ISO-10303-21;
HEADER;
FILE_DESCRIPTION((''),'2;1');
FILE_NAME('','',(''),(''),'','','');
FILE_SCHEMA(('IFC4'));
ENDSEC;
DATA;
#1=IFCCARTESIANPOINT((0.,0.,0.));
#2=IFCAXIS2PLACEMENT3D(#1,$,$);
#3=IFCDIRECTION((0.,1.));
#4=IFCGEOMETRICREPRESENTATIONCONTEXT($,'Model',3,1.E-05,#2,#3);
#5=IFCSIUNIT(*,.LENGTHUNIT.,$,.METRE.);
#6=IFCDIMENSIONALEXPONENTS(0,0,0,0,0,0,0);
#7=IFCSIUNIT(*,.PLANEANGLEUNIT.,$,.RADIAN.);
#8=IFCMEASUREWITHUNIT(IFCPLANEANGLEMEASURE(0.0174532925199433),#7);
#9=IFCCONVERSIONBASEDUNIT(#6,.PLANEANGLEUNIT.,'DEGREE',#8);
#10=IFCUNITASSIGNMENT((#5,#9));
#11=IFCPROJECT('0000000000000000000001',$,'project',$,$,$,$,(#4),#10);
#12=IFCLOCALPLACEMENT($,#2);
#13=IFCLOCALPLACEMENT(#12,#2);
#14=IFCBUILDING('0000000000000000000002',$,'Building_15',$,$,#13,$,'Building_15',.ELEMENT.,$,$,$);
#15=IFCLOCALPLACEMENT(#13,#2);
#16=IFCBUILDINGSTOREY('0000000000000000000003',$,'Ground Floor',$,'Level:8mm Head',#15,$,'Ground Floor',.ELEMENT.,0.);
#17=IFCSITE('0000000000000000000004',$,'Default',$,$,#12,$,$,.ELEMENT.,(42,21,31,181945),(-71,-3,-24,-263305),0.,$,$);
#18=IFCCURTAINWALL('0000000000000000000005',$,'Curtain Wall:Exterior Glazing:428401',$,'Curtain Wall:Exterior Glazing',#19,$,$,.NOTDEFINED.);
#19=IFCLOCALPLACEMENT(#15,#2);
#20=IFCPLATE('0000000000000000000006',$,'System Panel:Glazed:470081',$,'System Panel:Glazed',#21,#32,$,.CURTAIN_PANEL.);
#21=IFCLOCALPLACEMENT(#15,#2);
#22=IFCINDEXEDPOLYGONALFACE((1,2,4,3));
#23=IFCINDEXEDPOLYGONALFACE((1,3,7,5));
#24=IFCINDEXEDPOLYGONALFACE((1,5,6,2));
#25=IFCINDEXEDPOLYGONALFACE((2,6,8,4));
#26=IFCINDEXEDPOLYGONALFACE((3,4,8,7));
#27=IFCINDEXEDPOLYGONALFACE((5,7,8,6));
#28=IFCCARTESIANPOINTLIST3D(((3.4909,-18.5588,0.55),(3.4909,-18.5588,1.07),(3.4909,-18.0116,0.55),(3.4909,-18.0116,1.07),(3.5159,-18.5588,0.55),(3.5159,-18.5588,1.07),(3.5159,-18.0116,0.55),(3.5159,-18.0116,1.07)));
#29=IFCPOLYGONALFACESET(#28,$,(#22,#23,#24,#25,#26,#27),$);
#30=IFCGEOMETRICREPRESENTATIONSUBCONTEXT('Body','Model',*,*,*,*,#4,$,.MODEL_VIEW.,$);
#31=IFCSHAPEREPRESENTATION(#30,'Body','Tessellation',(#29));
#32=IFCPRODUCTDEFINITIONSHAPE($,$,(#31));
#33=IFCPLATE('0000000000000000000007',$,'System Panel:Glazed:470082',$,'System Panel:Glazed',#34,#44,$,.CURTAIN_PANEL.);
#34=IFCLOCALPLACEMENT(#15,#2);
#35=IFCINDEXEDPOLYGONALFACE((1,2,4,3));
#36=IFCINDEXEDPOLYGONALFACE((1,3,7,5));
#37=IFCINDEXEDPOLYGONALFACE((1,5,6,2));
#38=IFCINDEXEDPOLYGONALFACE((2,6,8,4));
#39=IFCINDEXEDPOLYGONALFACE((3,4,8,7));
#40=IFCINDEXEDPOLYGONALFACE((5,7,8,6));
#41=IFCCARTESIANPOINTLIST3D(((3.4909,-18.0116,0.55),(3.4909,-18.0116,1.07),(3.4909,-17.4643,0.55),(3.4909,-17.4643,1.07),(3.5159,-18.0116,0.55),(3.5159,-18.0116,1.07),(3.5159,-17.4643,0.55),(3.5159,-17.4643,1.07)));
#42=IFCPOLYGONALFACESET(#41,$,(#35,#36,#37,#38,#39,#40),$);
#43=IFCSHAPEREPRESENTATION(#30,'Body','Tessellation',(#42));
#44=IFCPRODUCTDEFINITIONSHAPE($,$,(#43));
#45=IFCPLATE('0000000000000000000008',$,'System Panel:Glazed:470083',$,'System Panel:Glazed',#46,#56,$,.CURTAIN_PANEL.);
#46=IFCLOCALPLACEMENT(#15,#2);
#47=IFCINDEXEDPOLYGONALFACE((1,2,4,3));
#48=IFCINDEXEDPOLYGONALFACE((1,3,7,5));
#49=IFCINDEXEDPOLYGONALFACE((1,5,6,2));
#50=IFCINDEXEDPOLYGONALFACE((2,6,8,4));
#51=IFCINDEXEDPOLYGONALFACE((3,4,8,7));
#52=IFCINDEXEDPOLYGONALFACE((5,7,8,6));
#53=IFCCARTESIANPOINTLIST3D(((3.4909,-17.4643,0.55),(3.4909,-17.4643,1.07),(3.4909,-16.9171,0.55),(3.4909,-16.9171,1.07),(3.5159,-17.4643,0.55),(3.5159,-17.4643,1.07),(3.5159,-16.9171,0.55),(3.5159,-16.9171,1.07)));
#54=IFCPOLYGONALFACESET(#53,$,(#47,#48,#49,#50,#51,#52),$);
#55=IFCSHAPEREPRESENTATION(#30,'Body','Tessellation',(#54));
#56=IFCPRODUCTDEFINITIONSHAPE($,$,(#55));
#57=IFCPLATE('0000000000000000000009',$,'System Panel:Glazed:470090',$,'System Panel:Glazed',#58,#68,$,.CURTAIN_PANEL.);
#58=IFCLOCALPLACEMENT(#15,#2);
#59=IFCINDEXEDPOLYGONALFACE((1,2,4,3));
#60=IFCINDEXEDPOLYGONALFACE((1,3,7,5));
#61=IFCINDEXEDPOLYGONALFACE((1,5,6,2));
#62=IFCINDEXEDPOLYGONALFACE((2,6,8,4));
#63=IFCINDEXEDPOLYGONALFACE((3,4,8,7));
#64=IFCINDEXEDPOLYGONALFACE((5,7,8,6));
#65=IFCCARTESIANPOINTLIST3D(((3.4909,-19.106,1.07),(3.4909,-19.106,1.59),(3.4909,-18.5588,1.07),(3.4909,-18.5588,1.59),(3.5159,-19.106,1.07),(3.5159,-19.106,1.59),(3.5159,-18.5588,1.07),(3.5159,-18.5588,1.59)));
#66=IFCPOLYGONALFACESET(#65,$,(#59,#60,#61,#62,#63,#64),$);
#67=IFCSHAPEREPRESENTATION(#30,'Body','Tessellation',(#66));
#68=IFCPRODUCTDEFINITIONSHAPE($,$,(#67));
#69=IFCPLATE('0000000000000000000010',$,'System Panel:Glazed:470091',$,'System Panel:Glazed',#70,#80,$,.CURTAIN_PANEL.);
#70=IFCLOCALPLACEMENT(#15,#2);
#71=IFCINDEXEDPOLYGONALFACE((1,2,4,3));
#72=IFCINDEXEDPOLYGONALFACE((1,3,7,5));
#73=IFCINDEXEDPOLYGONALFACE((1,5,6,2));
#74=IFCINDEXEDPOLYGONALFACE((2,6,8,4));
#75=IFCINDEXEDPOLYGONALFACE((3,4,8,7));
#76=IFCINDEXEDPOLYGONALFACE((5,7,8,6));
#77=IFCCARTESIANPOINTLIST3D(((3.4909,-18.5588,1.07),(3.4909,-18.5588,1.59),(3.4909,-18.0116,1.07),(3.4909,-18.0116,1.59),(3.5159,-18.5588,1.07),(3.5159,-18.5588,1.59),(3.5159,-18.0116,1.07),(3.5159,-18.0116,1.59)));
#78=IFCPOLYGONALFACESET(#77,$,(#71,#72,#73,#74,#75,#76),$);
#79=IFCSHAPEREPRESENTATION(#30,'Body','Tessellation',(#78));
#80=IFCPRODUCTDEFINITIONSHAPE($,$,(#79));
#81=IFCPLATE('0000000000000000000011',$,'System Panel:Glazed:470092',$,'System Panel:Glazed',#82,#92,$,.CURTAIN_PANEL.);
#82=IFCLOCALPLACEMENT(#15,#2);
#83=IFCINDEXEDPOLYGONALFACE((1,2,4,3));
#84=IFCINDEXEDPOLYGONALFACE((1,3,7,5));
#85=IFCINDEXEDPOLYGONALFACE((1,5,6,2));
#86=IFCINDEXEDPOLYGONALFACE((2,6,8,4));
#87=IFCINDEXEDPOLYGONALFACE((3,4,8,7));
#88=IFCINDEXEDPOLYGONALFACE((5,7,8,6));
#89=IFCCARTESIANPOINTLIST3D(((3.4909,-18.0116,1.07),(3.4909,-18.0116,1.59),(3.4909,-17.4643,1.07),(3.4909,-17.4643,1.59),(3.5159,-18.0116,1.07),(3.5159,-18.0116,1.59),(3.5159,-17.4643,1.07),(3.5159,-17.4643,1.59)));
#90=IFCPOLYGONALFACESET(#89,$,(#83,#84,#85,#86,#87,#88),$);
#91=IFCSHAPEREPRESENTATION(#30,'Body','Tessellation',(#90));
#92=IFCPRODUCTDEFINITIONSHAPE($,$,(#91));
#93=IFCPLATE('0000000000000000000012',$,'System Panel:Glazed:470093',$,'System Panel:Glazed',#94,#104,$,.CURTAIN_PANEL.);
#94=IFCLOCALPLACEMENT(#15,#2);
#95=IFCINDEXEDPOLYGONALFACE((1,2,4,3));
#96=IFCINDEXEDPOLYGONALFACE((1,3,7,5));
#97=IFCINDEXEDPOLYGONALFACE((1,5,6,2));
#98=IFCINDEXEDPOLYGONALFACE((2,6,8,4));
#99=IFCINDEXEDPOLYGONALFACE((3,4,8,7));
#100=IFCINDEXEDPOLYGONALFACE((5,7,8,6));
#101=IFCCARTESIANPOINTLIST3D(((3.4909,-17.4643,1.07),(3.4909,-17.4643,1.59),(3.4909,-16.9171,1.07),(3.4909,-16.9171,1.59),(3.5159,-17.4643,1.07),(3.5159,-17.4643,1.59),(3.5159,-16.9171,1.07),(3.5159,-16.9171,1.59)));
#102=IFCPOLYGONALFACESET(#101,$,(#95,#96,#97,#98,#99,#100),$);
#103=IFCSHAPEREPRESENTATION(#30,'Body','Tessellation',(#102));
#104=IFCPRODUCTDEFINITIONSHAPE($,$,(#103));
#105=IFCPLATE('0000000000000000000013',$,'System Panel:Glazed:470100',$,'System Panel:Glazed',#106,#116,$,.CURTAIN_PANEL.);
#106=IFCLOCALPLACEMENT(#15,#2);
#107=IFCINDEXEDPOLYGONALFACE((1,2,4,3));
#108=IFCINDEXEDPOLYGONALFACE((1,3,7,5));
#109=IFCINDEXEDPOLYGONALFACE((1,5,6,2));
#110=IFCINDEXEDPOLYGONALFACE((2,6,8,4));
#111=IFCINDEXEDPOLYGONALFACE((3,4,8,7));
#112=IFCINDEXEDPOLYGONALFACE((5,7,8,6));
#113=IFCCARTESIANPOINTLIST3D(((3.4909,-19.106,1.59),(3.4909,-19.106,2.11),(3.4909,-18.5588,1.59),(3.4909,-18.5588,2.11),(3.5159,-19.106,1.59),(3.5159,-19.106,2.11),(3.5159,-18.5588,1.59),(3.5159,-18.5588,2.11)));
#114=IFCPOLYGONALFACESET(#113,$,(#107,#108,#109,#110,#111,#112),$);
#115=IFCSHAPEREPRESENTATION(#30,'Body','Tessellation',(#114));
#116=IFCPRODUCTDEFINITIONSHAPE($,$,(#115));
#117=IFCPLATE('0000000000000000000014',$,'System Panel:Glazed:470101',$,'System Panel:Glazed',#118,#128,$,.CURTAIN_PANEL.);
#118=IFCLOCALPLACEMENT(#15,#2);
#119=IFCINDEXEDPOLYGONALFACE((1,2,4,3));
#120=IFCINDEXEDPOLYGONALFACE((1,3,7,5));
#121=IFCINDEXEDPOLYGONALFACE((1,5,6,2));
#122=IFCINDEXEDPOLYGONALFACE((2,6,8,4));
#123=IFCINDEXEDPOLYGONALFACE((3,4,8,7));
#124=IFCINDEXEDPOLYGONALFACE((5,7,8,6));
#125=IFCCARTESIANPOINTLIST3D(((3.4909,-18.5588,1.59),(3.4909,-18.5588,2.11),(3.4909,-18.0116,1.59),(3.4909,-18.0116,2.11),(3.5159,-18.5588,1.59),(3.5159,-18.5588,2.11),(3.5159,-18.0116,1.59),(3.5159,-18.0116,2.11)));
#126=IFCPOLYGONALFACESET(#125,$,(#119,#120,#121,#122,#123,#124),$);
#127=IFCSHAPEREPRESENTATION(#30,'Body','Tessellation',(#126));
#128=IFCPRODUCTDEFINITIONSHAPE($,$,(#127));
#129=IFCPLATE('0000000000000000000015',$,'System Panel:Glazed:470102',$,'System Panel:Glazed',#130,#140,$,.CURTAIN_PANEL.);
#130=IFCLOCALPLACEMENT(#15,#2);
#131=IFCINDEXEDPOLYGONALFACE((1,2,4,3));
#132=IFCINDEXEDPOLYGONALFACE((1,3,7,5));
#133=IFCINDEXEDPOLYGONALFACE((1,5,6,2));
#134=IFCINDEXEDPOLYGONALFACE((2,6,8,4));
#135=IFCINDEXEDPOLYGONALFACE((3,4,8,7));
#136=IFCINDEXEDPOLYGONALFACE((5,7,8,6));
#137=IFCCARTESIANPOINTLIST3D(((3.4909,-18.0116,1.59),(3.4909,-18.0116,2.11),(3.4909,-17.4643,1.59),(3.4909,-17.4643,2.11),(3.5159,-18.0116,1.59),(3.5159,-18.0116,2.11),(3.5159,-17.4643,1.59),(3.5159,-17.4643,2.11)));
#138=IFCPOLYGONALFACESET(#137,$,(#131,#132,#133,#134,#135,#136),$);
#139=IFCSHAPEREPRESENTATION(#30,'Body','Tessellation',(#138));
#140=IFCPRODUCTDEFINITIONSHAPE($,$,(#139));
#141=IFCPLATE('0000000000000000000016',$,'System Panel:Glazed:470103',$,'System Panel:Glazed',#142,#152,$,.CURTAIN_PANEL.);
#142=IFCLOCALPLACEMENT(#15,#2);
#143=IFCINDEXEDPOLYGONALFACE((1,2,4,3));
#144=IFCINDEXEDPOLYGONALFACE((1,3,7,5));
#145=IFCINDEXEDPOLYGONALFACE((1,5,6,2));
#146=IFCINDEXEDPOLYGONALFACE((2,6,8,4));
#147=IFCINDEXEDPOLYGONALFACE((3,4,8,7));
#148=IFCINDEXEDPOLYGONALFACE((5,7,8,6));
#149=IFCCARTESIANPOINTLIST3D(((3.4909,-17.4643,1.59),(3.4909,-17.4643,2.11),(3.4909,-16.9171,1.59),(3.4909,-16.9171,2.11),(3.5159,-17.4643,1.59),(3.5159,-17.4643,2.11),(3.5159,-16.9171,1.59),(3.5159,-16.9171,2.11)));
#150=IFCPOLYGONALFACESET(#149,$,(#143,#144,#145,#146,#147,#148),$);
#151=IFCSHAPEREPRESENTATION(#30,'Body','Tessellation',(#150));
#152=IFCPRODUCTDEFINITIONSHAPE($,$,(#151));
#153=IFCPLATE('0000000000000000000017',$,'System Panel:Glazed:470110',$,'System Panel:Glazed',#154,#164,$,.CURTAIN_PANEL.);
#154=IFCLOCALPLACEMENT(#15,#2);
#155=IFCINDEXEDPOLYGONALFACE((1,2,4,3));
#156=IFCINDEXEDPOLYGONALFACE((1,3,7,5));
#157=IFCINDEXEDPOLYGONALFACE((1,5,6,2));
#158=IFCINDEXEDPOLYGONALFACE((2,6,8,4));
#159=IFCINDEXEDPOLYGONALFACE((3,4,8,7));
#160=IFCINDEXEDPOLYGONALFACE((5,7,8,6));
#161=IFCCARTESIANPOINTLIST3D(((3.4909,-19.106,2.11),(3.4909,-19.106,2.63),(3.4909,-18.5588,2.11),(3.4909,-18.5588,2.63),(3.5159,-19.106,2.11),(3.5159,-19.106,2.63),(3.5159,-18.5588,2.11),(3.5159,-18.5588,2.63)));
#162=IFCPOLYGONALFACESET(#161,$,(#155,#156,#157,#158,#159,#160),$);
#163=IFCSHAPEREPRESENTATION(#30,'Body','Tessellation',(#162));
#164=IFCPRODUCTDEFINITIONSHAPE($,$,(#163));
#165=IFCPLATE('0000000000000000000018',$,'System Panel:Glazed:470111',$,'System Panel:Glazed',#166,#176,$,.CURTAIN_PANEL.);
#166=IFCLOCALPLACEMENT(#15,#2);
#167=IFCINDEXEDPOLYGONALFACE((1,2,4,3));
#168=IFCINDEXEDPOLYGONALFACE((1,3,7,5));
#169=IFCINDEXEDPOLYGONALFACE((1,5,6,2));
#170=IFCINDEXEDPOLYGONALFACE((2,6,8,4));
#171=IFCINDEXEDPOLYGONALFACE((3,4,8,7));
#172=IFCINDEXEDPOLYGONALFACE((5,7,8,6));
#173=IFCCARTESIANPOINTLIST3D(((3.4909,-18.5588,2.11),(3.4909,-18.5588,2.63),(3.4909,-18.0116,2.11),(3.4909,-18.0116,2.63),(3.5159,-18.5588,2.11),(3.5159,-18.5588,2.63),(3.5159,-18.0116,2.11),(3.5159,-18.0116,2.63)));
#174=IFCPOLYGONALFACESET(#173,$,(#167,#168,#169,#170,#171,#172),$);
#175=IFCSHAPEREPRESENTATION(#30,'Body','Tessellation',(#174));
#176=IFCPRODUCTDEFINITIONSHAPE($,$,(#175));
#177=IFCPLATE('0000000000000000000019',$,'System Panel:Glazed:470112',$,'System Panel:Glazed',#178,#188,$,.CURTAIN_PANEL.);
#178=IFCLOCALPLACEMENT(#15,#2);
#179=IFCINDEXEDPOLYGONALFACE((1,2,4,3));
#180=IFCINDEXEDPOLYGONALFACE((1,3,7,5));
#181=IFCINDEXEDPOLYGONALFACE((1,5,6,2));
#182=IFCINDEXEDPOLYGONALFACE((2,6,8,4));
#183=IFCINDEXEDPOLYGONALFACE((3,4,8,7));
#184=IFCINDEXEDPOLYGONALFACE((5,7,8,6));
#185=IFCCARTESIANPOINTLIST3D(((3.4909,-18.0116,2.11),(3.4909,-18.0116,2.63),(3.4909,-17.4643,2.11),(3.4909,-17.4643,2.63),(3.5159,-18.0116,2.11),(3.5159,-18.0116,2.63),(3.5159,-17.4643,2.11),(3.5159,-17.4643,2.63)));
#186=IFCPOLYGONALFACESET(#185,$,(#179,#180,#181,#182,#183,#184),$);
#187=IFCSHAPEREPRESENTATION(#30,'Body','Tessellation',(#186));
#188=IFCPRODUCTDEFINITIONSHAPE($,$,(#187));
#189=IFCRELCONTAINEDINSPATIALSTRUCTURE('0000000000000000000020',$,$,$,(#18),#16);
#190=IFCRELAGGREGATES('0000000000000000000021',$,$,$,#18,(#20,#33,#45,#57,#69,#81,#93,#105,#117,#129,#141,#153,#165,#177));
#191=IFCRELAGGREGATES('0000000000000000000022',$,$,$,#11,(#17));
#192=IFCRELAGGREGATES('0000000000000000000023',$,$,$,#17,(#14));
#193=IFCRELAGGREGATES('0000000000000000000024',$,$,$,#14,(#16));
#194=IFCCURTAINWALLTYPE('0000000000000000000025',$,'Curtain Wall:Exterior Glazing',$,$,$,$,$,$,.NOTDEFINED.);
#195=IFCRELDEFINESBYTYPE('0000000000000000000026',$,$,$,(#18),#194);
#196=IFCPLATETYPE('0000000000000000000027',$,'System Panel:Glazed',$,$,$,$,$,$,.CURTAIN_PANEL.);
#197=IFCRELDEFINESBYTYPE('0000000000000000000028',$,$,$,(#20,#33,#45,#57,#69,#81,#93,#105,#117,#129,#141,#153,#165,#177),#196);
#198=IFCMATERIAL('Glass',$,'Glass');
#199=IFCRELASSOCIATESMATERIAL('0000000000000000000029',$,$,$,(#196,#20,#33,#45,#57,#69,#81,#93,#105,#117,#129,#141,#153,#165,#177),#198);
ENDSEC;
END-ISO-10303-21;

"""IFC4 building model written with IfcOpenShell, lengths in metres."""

from ifc_helpers import new_model, entity, si_unit, converted_unit, direction, frame, origin, place, context, subcontext, project, spatial, indexed_curve, outline, extrude, source, transform, mapped, material, type_object, type_shapes, element, aggregate, save


model = new_model("IFC4")

# Units and contexts
model_context = context("Model", 3, precision=1e-05, world=origin(), true_north=direction((0.0, 1.0)))
body_context = subcontext(model_context, "Body", "Model", "MODEL_VIEW")
ifc_project = project(units=[si_unit("LENGTHUNIT", "METRE"), converted_unit("PLANEANGLEUNIT", "DEGREE", entity("IfcPlaneAngleMeasure", 0.0174532925199433), si_unit("PLANEANGLEUNIT", "RADIAN"), dimensions=[0, 0, 0, 0, 0, 0, 0])], contexts=[model_context])

# Site, building, storey
site_placement = place(None, origin())
site = spatial("IfcSite", under=ifc_project, at=site_placement, Name="Default", CompositionType="ELEMENT", RefLatitude=(42, 21, 31, 181945), RefLongitude=(-71, -3, -24, -263305), RefElevation=0.0)
building_placement = place(site_placement, origin())
building = spatial("IfcBuilding", under=site, at=building_placement, Name="Building_15", LongName="Building_15", CompositionType="ELEMENT")
storey_placement = place(building_placement, origin())
storey = spatial("IfcBuildingStorey", under=building, at=storey_placement, Name="Ground Floor", ObjectType="Level:8mm Head", LongName="Ground Floor", CompositionType="ELEMENT", Elevation=0.0)

# Curtain wall, plates
curtain_wall_type = type_object("IfcCurtainWallType", Name="Curtain Wall:Exterior Glazing", PredefinedType="NOTDEFINED")
curtain_wall_placement = place(storey_placement, origin())
curtain_wall = element("IfcCurtainWall", 1, at=curtain_wall_placement, inside=storey, type_object=curtain_wall_type, Name="Curtain Wall:Exterior Glazing:428401", ObjectType="Curtain Wall:Exterior Glazing", PredefinedType="NOTDEFINED")
ifc_material_1 = material(Name="Glass", Category="Glass")
plate_type_1 = type_object("IfcPlateType", Name="System Panel:Glazed", PredefinedType="CURTAIN_PANEL", material=ifc_material_1)
shared_shape_1 = source(origin(), body_context, "Body", "SweptSolid", [
    extrude(outline(indexed_curve([(-0.0125, -0.2736), (0.0125, -0.2736), (0.0125, 0.2736), (-0.0125, 0.2736), (-0.0125, -0.2736)], self_intersect=False)), frame((0.0, 0.037, 0.0), z_axis=(0.0, 0.0, 1.0), x_axis=(0.0, 1.0, 0.0)), (0.0, 0.0, 1.0), 0.52),
])
type_shapes(plate_type_1, [shared_shape_1])
plate_1_placement = place(curtain_wall_placement, frame((3.5404, -18.2852, 0.55), z_axis=(0.0, 0.0, 1.0), x_axis=(0.0, 1.0, 0.0)))
plate_1 = element("IfcPlate", 2, at=plate_1_placement, type_object=plate_type_1, material=ifc_material_1, Name="System Panel:Glazed:470081", ObjectType="System Panel:Glazed", PredefinedType="CURTAIN_PANEL", context=body_context, shape_type="MappedRepresentation", body=[
    mapped(shared_shape_1, transform((0.0, 0.0, 0.0), scale=1.0)),
])
plate_2_placement = place(curtain_wall_placement, frame((3.5404, -17.738, 0.55), z_axis=(0.0, 0.0, 1.0), x_axis=(0.0, 1.0, 0.0)))
plate_2 = element("IfcPlate", 3, at=plate_2_placement, type_object=plate_type_1, material=ifc_material_1, Name="System Panel:Glazed:470082", ObjectType="System Panel:Glazed", PredefinedType="CURTAIN_PANEL", context=body_context, shape_type="MappedRepresentation", body=[
    mapped(shared_shape_1, transform((0.0, 0.0, 0.0), scale=1.0)),
])
plate_3_placement = place(curtain_wall_placement, frame((3.5404, -17.1907, 0.55), z_axis=(0.0, 0.0, 1.0), x_axis=(0.0, 1.0, 0.0)))
plate_3 = element("IfcPlate", 4, at=plate_3_placement, type_object=plate_type_1, material=ifc_material_1, Name="System Panel:Glazed:470083", ObjectType="System Panel:Glazed", PredefinedType="CURTAIN_PANEL", context=body_context, shape_type="MappedRepresentation", body=[
    mapped(shared_shape_1, transform((0.0, 0.0, 0.0), scale=1.0)),
])
plate_4_placement = place(curtain_wall_placement, frame((3.5404, -18.8324, 1.07), z_axis=(0.0, 0.0, 1.0), x_axis=(0.0, 1.0, 0.0)))
plate_4 = element("IfcPlate", 5, at=plate_4_placement, type_object=plate_type_1, material=ifc_material_1, Name="System Panel:Glazed:470090", ObjectType="System Panel:Glazed", PredefinedType="CURTAIN_PANEL", context=body_context, shape_type="MappedRepresentation", body=[
    mapped(shared_shape_1, transform((0.0, 0.0, 0.0), scale=1.0)),
])
plate_5_placement = place(curtain_wall_placement, frame((3.5404, -18.2852, 1.07), z_axis=(0.0, 0.0, 1.0), x_axis=(0.0, 1.0, 0.0)))
plate_5 = element("IfcPlate", 6, at=plate_5_placement, type_object=plate_type_1, material=ifc_material_1, Name="System Panel:Glazed:470091", ObjectType="System Panel:Glazed", PredefinedType="CURTAIN_PANEL", context=body_context, shape_type="MappedRepresentation", body=[
    mapped(shared_shape_1, transform((0.0, 0.0, 0.0), scale=1.0)),
])
plate_6_placement = place(curtain_wall_placement, frame((3.5404, -17.738, 1.07), z_axis=(0.0, 0.0, 1.0), x_axis=(0.0, 1.0, 0.0)))
plate_6 = element("IfcPlate", 7, at=plate_6_placement, type_object=plate_type_1, material=ifc_material_1, Name="System Panel:Glazed:470092", ObjectType="System Panel:Glazed", PredefinedType="CURTAIN_PANEL", context=body_context, shape_type="MappedRepresentation", body=[
    mapped(shared_shape_1, transform((0.0, 0.0, 0.0), scale=1.0)),
])
plate_7_placement = place(curtain_wall_placement, frame((3.5404, -17.1907, 1.07), z_axis=(0.0, 0.0, 1.0), x_axis=(0.0, 1.0, 0.0)))
plate_7 = element("IfcPlate", 8, at=plate_7_placement, type_object=plate_type_1, material=ifc_material_1, Name="System Panel:Glazed:470093", ObjectType="System Panel:Glazed", PredefinedType="CURTAIN_PANEL", context=body_context, shape_type="MappedRepresentation", body=[
    mapped(shared_shape_1, transform((0.0, 0.0, 0.0), scale=1.0)),
])
plate_8_placement = place(curtain_wall_placement, frame((3.5404, -18.8324, 1.59), z_axis=(0.0, 0.0, 1.0), x_axis=(0.0, 1.0, 0.0)))
plate_8 = element("IfcPlate", 9, at=plate_8_placement, type_object=plate_type_1, material=ifc_material_1, Name="System Panel:Glazed:470100", ObjectType="System Panel:Glazed", PredefinedType="CURTAIN_PANEL", context=body_context, shape_type="MappedRepresentation", body=[
    mapped(shared_shape_1, transform((0.0, 0.0, 0.0), scale=1.0)),
])
plate_9_placement = place(curtain_wall_placement, frame((3.5404, -18.2852, 1.59), z_axis=(0.0, 0.0, 1.0), x_axis=(0.0, 1.0, 0.0)))
plate_9 = element("IfcPlate", 10, at=plate_9_placement, type_object=plate_type_1, material=ifc_material_1, Name="System Panel:Glazed:470101", ObjectType="System Panel:Glazed", PredefinedType="CURTAIN_PANEL", context=body_context, shape_type="MappedRepresentation", body=[
    mapped(shared_shape_1, transform((0.0, 0.0, 0.0), scale=1.0)),
])
plate_10_placement = place(curtain_wall_placement, frame((3.5404, -17.738, 1.59), z_axis=(0.0, 0.0, 1.0), x_axis=(0.0, 1.0, 0.0)))
plate_10 = element("IfcPlate", 11, at=plate_10_placement, type_object=plate_type_1, material=ifc_material_1, Name="System Panel:Glazed:470102", ObjectType="System Panel:Glazed", PredefinedType="CURTAIN_PANEL", context=body_context, shape_type="MappedRepresentation", body=[
    mapped(shared_shape_1, transform((0.0, 0.0, 0.0), scale=1.0)),
])
plate_11_placement = place(curtain_wall_placement, frame((3.5404, -17.1907, 1.59), z_axis=(0.0, 0.0, 1.0), x_axis=(0.0, 1.0, 0.0)))
plate_11 = element("IfcPlate", 12, at=plate_11_placement, type_object=plate_type_1, material=ifc_material_1, Name="System Panel:Glazed:470103", ObjectType="System Panel:Glazed", PredefinedType="CURTAIN_PANEL", context=body_context, shape_type="MappedRepresentation", body=[
    mapped(shared_shape_1, transform((0.0, 0.0, 0.0), scale=1.0)),
])
plate_12_placement = place(curtain_wall_placement, frame((3.5404, -18.8324, 2.11), z_axis=(0.0, 0.0, 1.0), x_axis=(0.0, 1.0, 0.0)))
plate_12 = element("IfcPlate", 13, at=plate_12_placement, type_object=plate_type_1, material=ifc_material_1, Name="System Panel:Glazed:470110", ObjectType="System Panel:Glazed", PredefinedType="CURTAIN_PANEL", context=body_context, shape_type="MappedRepresentation", body=[
    mapped(shared_shape_1, transform((0.0, 0.0, 0.0), scale=1.0)),
])
plate_13_placement = place(curtain_wall_placement, frame((3.5404, -18.2852, 2.11), z_axis=(0.0, 0.0, 1.0), x_axis=(0.0, 1.0, 0.0)))
plate_13 = element("IfcPlate", 14, at=plate_13_placement, type_object=plate_type_1, material=ifc_material_1, Name="System Panel:Glazed:470111", ObjectType="System Panel:Glazed", PredefinedType="CURTAIN_PANEL", context=body_context, shape_type="MappedRepresentation", body=[
    mapped(shared_shape_1, transform((0.0, 0.0, 0.0), scale=1.0)),
])
plate_14_placement = place(curtain_wall_placement, frame((3.5404, -17.738, 2.11), z_axis=(0.0, 0.0, 1.0), x_axis=(0.0, 1.0, 0.0)))
plate_14 = element("IfcPlate", 15, at=plate_14_placement, type_object=plate_type_1, material=ifc_material_1, Name="System Panel:Glazed:470112", ObjectType="System Panel:Glazed", PredefinedType="CURTAIN_PANEL", context=body_context, shape_type="MappedRepresentation", body=[
    mapped(shared_shape_1, transform((0.0, 0.0, 0.0), scale=1.0)),
])
aggregate(curtain_wall, [plate_1, plate_2, plate_3, plate_4, plate_5, plate_6, plate_7, plate_8, plate_9, plate_10, plate_11, plate_12, plate_13, plate_14])

save(model, "model.ifc")
